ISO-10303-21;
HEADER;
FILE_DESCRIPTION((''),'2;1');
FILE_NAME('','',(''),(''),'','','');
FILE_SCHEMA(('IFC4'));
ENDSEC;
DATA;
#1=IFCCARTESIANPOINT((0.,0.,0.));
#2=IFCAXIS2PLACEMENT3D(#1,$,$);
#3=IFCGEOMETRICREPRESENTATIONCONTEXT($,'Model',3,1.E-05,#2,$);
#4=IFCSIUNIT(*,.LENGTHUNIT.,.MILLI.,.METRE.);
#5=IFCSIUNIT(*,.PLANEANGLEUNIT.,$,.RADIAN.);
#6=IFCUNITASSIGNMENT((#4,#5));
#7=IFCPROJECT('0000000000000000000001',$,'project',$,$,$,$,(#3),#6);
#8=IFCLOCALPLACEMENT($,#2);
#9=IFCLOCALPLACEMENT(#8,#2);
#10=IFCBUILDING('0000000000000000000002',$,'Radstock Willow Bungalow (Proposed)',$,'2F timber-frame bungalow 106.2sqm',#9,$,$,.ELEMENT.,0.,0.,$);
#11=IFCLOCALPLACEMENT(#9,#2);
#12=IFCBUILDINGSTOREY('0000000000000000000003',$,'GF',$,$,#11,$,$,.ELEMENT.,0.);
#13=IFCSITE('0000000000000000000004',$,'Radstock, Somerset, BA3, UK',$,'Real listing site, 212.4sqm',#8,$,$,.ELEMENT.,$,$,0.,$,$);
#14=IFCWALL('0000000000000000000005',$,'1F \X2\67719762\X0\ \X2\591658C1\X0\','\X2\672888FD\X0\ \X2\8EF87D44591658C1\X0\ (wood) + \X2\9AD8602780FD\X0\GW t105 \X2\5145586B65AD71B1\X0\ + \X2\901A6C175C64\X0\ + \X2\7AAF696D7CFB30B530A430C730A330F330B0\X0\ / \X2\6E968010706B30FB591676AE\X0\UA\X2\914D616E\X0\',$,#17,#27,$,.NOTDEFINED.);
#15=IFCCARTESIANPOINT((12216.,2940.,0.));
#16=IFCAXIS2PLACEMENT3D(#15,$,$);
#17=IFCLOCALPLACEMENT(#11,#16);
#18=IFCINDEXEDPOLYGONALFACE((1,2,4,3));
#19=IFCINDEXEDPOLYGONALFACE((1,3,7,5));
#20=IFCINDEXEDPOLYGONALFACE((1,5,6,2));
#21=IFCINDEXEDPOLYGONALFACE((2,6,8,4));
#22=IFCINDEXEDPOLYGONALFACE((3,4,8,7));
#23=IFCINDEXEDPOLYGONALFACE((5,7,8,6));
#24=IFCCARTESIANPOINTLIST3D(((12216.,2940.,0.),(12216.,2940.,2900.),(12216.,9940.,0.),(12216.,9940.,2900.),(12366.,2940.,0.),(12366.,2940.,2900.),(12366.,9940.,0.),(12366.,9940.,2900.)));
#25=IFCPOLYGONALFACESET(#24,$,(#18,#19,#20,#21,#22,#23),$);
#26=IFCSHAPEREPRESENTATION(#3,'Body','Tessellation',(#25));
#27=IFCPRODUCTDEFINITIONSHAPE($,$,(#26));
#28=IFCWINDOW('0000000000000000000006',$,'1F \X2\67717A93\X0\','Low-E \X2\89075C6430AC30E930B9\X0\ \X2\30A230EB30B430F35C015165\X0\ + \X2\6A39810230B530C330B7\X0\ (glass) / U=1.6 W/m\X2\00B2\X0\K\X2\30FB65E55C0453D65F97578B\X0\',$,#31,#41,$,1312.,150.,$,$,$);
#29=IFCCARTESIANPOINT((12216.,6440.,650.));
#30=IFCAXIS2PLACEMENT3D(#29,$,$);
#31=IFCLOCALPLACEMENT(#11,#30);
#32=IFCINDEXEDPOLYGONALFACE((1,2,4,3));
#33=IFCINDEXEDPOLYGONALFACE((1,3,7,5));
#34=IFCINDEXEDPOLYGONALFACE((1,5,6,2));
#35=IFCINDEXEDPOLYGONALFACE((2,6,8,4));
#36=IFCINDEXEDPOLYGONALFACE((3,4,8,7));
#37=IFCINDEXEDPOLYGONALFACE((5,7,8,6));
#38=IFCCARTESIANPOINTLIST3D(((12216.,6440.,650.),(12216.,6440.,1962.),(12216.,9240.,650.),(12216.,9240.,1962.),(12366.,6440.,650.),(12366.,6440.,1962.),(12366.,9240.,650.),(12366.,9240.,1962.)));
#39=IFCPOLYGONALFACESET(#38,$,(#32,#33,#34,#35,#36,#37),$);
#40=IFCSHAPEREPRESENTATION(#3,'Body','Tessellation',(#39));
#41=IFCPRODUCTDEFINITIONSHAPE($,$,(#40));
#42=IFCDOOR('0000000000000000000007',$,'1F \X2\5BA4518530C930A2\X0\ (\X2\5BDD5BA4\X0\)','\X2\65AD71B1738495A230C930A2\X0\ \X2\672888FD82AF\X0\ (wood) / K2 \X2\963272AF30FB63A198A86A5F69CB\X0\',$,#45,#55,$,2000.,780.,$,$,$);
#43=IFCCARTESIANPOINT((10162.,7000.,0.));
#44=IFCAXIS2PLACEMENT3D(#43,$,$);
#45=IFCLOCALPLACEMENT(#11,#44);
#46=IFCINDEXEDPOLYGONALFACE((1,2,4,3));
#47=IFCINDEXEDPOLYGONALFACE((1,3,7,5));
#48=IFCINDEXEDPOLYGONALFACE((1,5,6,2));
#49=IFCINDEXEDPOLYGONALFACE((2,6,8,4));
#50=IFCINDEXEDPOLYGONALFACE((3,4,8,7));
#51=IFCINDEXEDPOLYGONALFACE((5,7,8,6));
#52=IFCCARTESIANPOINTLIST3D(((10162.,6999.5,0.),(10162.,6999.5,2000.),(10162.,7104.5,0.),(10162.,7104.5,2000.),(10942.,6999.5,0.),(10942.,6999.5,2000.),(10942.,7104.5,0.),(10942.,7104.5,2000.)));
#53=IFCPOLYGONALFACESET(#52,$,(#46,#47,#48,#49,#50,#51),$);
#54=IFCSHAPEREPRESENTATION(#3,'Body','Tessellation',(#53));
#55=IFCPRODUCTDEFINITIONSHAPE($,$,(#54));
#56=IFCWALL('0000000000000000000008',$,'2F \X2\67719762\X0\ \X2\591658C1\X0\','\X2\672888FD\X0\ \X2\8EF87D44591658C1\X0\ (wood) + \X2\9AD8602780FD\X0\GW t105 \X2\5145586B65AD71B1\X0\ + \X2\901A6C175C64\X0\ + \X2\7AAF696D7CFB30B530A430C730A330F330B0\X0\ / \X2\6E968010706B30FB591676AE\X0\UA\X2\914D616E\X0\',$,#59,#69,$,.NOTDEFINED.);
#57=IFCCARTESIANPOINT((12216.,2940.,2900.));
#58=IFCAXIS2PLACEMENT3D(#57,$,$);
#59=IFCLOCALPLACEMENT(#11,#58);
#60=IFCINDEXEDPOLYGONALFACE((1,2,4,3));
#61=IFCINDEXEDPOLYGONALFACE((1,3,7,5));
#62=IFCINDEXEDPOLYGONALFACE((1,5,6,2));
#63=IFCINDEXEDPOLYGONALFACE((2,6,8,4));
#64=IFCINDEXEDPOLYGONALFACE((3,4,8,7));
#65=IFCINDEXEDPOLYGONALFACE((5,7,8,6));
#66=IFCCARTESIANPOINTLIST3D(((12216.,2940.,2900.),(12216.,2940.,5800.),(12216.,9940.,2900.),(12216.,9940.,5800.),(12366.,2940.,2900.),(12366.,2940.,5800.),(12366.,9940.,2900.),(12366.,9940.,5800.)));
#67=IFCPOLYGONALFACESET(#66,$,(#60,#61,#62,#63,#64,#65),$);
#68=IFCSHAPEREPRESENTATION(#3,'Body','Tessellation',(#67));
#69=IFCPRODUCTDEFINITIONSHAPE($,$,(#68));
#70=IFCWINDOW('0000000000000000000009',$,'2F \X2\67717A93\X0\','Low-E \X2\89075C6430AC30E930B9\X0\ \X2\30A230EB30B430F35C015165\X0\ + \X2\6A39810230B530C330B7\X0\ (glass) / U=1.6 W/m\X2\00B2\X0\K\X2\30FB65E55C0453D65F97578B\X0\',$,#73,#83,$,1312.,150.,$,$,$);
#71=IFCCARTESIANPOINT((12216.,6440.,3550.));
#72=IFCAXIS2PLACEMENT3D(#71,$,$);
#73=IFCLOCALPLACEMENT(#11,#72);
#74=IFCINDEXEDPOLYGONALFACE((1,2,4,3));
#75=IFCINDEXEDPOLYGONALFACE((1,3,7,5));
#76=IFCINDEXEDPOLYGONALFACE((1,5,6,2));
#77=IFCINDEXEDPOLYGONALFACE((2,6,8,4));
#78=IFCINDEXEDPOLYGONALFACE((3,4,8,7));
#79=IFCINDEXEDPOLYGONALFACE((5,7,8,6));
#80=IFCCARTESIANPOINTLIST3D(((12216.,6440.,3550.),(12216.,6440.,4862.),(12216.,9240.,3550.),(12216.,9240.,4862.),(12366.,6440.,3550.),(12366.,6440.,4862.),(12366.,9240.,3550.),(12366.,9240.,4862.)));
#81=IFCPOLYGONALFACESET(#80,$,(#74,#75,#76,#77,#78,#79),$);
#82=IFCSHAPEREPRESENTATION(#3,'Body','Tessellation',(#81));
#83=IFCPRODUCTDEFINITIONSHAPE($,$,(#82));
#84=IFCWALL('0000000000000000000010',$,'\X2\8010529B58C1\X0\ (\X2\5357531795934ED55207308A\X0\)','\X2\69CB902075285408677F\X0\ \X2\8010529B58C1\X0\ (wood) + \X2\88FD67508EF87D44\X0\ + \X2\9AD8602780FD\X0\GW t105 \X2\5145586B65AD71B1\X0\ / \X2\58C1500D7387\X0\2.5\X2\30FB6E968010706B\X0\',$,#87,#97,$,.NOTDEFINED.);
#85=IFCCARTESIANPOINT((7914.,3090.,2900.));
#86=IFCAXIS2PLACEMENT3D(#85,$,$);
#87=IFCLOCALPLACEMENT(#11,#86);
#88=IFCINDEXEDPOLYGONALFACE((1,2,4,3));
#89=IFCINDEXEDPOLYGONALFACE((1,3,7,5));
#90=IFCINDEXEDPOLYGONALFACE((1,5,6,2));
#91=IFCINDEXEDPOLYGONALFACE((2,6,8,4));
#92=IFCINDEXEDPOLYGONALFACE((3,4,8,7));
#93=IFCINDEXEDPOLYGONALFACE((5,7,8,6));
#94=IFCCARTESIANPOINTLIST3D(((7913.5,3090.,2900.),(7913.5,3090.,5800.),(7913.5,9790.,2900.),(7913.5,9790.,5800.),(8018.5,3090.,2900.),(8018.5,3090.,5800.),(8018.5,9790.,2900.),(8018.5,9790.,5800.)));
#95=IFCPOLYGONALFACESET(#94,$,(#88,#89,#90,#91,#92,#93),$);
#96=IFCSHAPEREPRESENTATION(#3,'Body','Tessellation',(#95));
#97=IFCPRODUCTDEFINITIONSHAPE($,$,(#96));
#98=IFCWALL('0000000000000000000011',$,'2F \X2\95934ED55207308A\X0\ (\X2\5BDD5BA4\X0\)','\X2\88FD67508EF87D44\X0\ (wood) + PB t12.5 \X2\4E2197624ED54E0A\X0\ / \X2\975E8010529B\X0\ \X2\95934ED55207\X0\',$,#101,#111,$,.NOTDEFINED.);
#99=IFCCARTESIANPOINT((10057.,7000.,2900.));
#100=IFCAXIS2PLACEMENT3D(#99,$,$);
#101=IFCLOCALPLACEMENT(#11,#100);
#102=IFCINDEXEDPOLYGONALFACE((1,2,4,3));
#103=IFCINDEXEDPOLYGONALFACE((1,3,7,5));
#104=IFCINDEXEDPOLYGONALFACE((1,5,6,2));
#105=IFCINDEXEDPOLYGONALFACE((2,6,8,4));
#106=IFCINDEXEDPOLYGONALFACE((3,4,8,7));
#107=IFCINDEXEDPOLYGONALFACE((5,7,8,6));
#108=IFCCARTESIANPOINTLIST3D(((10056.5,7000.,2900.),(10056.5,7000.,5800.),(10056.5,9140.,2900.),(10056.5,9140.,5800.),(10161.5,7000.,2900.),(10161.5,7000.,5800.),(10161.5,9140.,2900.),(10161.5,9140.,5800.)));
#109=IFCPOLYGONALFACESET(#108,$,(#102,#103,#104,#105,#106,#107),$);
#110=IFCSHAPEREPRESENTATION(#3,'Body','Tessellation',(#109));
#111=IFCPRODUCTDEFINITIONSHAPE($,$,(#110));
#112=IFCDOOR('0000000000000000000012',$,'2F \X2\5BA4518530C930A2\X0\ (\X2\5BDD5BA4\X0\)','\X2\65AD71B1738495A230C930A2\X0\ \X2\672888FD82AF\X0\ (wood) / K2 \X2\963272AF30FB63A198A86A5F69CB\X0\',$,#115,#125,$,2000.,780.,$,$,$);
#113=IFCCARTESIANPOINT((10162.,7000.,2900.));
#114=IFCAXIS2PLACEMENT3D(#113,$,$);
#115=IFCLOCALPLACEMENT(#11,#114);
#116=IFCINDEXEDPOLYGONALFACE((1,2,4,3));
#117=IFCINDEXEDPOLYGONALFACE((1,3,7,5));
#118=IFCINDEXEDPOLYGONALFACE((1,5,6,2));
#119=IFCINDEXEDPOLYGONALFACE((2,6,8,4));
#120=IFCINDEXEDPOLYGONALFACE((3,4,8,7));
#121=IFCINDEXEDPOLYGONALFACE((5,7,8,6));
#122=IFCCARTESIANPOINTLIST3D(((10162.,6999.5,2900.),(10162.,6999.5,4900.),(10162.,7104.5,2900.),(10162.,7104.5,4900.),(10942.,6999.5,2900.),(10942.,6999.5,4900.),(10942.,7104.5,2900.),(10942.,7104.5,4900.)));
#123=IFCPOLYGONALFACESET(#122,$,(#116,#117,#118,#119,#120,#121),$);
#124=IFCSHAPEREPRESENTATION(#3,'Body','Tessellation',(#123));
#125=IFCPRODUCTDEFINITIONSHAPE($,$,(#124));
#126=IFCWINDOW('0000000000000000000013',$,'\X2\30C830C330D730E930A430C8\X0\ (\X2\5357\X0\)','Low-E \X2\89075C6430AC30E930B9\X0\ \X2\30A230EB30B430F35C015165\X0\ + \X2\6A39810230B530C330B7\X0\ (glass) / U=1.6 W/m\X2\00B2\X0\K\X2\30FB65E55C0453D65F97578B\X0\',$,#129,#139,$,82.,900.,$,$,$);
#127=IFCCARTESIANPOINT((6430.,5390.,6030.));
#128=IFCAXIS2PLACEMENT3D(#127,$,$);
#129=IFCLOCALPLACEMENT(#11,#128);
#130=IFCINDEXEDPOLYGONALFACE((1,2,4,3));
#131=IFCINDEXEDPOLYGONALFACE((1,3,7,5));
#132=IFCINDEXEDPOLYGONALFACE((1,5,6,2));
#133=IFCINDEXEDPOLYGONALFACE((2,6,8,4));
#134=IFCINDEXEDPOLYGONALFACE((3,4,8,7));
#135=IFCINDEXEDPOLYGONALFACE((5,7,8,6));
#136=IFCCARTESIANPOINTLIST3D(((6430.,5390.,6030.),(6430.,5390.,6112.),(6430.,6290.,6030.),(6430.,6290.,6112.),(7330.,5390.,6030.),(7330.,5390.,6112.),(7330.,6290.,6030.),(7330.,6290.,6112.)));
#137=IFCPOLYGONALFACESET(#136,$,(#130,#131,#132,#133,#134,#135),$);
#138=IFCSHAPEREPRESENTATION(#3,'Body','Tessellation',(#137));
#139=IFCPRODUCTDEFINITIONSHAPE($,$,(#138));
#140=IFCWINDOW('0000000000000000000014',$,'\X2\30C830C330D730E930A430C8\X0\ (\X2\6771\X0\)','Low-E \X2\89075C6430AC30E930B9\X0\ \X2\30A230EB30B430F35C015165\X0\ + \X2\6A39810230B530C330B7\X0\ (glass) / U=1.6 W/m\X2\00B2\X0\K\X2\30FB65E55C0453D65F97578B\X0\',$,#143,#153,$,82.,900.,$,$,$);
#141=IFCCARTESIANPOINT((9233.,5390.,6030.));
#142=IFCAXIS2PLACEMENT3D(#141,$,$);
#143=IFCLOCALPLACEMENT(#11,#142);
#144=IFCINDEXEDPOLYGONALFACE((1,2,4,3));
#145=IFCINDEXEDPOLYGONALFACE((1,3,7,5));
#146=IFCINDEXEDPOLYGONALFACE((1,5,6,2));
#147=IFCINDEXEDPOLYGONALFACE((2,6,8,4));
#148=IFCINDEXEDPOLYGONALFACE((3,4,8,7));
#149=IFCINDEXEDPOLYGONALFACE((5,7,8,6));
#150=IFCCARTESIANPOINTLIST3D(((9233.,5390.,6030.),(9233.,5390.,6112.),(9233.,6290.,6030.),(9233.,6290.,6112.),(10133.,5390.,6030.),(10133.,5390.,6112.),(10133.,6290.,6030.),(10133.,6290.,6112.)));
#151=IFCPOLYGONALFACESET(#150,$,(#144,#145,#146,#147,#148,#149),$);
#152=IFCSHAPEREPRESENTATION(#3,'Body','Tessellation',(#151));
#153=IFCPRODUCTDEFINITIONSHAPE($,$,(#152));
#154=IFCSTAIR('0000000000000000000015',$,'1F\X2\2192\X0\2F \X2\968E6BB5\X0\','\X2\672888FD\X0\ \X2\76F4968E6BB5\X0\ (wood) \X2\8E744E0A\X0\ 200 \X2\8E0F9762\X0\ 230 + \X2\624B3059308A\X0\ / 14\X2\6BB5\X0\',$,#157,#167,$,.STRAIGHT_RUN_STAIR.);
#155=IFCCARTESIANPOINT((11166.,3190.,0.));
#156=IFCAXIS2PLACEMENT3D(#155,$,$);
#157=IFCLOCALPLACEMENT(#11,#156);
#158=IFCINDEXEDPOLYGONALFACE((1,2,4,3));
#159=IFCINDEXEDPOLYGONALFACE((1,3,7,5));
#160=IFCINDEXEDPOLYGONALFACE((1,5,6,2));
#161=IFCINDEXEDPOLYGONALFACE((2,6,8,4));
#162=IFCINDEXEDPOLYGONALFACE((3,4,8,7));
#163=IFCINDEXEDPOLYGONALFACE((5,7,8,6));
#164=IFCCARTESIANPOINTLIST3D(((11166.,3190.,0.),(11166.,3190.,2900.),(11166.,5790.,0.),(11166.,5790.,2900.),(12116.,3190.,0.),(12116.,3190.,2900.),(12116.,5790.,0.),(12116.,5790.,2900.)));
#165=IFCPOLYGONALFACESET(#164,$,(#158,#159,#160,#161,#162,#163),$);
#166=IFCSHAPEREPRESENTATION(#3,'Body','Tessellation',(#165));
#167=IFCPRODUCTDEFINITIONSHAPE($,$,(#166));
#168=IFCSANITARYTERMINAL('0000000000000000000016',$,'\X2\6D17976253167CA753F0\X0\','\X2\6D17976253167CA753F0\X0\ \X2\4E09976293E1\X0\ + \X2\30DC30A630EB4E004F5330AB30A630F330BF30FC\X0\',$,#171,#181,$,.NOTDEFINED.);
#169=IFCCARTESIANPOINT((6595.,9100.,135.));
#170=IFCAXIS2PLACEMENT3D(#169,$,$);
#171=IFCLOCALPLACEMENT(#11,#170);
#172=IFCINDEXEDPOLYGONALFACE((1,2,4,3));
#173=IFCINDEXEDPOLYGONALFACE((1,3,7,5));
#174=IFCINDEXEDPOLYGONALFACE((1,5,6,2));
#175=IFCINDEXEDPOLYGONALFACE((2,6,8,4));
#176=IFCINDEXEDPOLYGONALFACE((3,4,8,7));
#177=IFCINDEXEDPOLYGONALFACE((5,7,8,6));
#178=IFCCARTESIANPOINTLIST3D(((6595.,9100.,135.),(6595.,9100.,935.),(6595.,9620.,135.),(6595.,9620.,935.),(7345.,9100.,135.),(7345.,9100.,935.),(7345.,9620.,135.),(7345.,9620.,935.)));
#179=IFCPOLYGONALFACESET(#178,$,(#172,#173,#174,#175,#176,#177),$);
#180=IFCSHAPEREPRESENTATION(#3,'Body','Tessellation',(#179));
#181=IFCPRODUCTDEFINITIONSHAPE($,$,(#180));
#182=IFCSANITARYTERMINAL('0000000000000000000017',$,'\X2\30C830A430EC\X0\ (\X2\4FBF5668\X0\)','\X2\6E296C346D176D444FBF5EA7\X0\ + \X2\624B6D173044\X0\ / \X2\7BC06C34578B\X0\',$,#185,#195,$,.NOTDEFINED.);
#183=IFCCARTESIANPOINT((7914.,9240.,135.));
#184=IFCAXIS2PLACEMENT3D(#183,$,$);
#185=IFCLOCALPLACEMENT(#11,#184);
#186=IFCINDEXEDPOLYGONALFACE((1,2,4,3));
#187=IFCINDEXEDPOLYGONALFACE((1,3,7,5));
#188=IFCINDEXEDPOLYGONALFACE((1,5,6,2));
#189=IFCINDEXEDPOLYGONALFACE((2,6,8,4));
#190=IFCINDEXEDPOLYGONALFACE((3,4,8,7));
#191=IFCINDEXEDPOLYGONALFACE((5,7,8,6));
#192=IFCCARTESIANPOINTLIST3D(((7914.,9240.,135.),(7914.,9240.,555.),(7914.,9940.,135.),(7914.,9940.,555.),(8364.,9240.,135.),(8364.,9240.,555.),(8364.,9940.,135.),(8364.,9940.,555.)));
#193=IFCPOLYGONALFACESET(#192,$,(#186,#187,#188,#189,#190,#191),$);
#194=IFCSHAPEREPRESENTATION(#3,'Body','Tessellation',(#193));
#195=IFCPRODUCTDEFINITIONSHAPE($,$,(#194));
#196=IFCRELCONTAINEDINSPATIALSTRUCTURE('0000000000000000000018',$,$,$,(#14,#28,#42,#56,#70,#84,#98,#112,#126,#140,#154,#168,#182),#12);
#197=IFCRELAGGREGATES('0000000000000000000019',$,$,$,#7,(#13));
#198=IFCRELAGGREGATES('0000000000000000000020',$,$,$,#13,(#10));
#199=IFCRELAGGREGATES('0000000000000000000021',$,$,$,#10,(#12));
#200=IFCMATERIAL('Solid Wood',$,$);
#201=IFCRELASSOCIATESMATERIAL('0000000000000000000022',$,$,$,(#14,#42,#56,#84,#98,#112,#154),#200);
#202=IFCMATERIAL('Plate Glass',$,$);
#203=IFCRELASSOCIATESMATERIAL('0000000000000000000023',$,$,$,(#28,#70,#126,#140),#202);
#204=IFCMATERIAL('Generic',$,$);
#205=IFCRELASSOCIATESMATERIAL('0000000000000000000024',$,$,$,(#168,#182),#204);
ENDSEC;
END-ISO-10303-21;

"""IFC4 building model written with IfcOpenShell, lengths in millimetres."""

from ifc_helpers import new_model, si_unit, frame, frame_2d, origin, place, context, project, spatial, rectangle, extrude, material, element, fill, save


model = new_model("IFC4")

# Units and contexts
model_context = context("Model", 3, precision=1e-05, world=origin())
ifc_project = project(units=[si_unit("LENGTHUNIT", "METRE", prefix="MILLI"), si_unit("PLANEANGLEUNIT", "RADIAN")], contexts=[model_context])

# Site, building, storey
site_placement = place(None, origin())
site = spatial("IfcSite", under=ifc_project, at=site_placement, Name="Radstock, Somerset, BA3, UK", ObjectType="Real listing site, 212.4sqm", CompositionType="ELEMENT", RefElevation=0.0)
building_placement = place(site_placement, origin())
building = spatial("IfcBuilding", under=site, at=building_placement, Name="Radstock Willow Bungalow (Proposed)", ObjectType="2F timber-frame bungalow 106.2sqm", CompositionType="ELEMENT", ElevationOfRefHeight=0.0, ElevationOfTerrain=0.0)
storey_placement = place(building_placement, origin())
storey = spatial("IfcBuildingStorey", under=building, at=storey_placement, Name="GF", CompositionType="ELEMENT", Elevation=0.0)

# Wall, opening, window
ifc_material_1 = material(Name="Solid Wood")
wall_1_placement = place(storey_placement, frame((12216.0, 2940.0, 0.0)))
wall_1 = element("IfcWall", 1, at=wall_1_placement, inside=storey, material=ifc_material_1, Name="1F 東面 外壁", Description="木製 軸組外壁 (wood) + 高性能GW t105 充填断熱 + 通気層 + 窯業系サイディング / 準耐火・外皮UA配慮", PredefinedType="NOTDEFINED", context=model_context, shape_type="SweptSolid", body=[
    extrude(rectangle(XDim=150.0, YDim=7000.0, at=frame_2d((75.0, 3500.0))), frame((12216.0, 2940.0, 0.0)), (0.0, 0.0, 1.0), 2900.0),
])
opening_1_placement = place(storey_placement, frame((12216.0, 6440.0, 650.0)))
opening_1 = element("IfcOpeningElement", 2, at=opening_1_placement, cuts=wall_1, PredefinedType="NOTDEFINED", context=model_context, shape_type="SweptSolid", body=[
    extrude(rectangle(XDim=150.0, YDim=2800.0, at=frame_2d((75.0, 1400.0))), frame((12216.0, 6440.0, 650.0)), (0.0, 0.0, 1.0), 1312.0),
])
ifc_material_2 = material(Name="Plate Glass")
window_1_placement = place(storey_placement, frame((12216.0, 6440.0, 650.0)))
window_1 = element("IfcWindow", 3, at=window_1_placement, inside=storey, material=ifc_material_2, Name="1F 東窓", Description="Low-E 複層ガラス アルゴン封入 + 樹脂サッシ (glass) / U=1.6 W/m²K・日射取得型", OverallHeight=1312.0, OverallWidth=150.0, context=model_context, shape_type="SweptSolid", body=[
    extrude(rectangle(XDim=150.0, YDim=2800.0, at=frame_2d((75.0, 1400.0))), frame((12216.0, 6440.0, 650.0)), (0.0, 0.0, 1.0), 1312.0),
])
fill(opening_1, window_1)

# Door
door_1_placement = place(storey_placement, frame((10162.0, 7000.0, 0.0)))
element("IfcDoor", 4, at=door_1_placement, inside=storey, material=ifc_material_1, Name="1F 室内ドア (寝室)", Description="断熱玄関ドア 木製芯 (wood) / K2 防犯・採風機構", OverallHeight=2000.0, OverallWidth=780.0, context=model_context, shape_type="SweptSolid", body=[
    extrude(rectangle(XDim=780.0, YDim=105.0, at=frame_2d((390.0, 52.0))), frame((10162.0, 7000.0, 0.0)), (0.0, 0.0, 1.0), 2000.0),
])

# Wall, opening, window
wall_2_placement = place(storey_placement, frame((12216.0, 2940.0, 2900.0)))
wall_2 = element("IfcWall", 5, at=wall_2_placement, inside=storey, material=ifc_material_1, Name="2F 東面 外壁", Description="木製 軸組外壁 (wood) + 高性能GW t105 充填断熱 + 通気層 + 窯業系サイディング / 準耐火・外皮UA配慮", PredefinedType="NOTDEFINED", context=model_context, shape_type="SweptSolid", body=[
    extrude(rectangle(XDim=150.0, YDim=7000.0, at=frame_2d((75.0, 3500.0))), frame((12216.0, 2940.0, 2900.0)), (0.0, 0.0, 1.0), 2900.0),
])
opening_2_placement = place(storey_placement, frame((12216.0, 6440.0, 3550.0)))
opening_2 = element("IfcOpeningElement", 6, at=opening_2_placement, cuts=wall_2, PredefinedType="NOTDEFINED", context=model_context, shape_type="SweptSolid", body=[
    extrude(rectangle(XDim=150.0, YDim=2800.0, at=frame_2d((75.0, 1400.0))), frame((12216.0, 6440.0, 3550.0)), (0.0, 0.0, 1.0), 1312.0),
])
window_2_placement = place(storey_placement, frame((12216.0, 6440.0, 3550.0)))
window_2 = element("IfcWindow", 7, at=window_2_placement, inside=storey, material=ifc_material_2, Name="2F 東窓", Description="Low-E 複層ガラス アルゴン封入 + 樹脂サッシ (glass) / U=1.6 W/m²K・日射取得型", OverallHeight=1312.0, OverallWidth=150.0, context=model_context, shape_type="SweptSolid", body=[
    extrude(rectangle(XDim=150.0, YDim=2800.0, at=frame_2d((75.0, 1400.0))), frame((12216.0, 6440.0, 3550.0)), (0.0, 0.0, 1.0), 1312.0),
])
fill(opening_2, window_2)

# Walls
wall_3_placement = place(storey_placement, frame((7914.0, 3090.0, 2900.0)))
element("IfcWall", 8, at=wall_3_placement, inside=storey, material=ifc_material_1, Name="耐力壁 (南北間仕切り)", Description="構造用合板 耐力壁 (wood) + 製材軸組 + 高性能GW t105 充填断熱 / 壁倍率2.5・準耐火", PredefinedType="NOTDEFINED", context=model_context, shape_type="SweptSolid", body=[
    extrude(rectangle(XDim=105.0, YDim=6700.0, at=frame_2d((52.0, 3350.0))), frame((7914.0, 3090.0, 2900.0)), (0.0, 0.0, 1.0), 2900.0),
])
wall_4_placement = place(storey_placement, frame((10057.0, 7000.0, 2900.0)))
element("IfcWall", 9, at=wall_4_placement, inside=storey, material=ifc_material_1, Name="2F 間仕切り (寝室)", Description="製材軸組 (wood) + PB t12.5 両面仕上 / 非耐力 間仕切", PredefinedType="NOTDEFINED", context=model_context, shape_type="SweptSolid", body=[
    extrude(rectangle(XDim=105.0, YDim=2140.0, at=frame_2d((52.0, 1070.0))), frame((10057.0, 7000.0, 2900.0)), (0.0, 0.0, 1.0), 2900.0),
])

# Door
door_2_placement = place(storey_placement, frame((10162.0, 7000.0, 2900.0)))
element("IfcDoor", 10, at=door_2_placement, inside=storey, material=ifc_material_1, Name="2F 室内ドア (寝室)", Description="断熱玄関ドア 木製芯 (wood) / K2 防犯・採風機構", OverallHeight=2000.0, OverallWidth=780.0, context=model_context, shape_type="SweptSolid", body=[
    extrude(rectangle(XDim=780.0, YDim=105.0, at=frame_2d((390.0, 52.0))), frame((10162.0, 7000.0, 2900.0)), (0.0, 0.0, 1.0), 2000.0),
])

# Windows
window_3_placement = place(storey_placement, frame((6430.0, 5390.0, 6030.0)))
element("IfcWindow", 11, at=window_3_placement, inside=storey, material=ifc_material_2, Name="トップライト (南)", Description="Low-E 複層ガラス アルゴン封入 + 樹脂サッシ (glass) / U=1.6 W/m²K・日射取得型", OverallHeight=82.0, OverallWidth=900.0, context=model_context, shape_type="SweptSolid", body=[
    extrude(rectangle(XDim=900.0, YDim=900.0, at=frame_2d((450.0, 450.0))), frame((6430.0, 5390.0, 6030.0)), (0.0, 0.0, 1.0), 82.0),
])
window_4_placement = place(storey_placement, frame((9233.0, 5390.0, 6030.0)))
element("IfcWindow", 12, at=window_4_placement, inside=storey, material=ifc_material_2, Name="トップライト (東)", Description="Low-E 複層ガラス アルゴン封入 + 樹脂サッシ (glass) / U=1.6 W/m²K・日射取得型", OverallHeight=82.0, OverallWidth=900.0, context=model_context, shape_type="SweptSolid", body=[
    extrude(rectangle(XDim=900.0, YDim=900.0, at=frame_2d((450.0, 450.0))), frame((9233.0, 5390.0, 6030.0)), (0.0, 0.0, 1.0), 82.0),
])

# Stair
stair_placement = place(storey_placement, frame((11166.0, 3190.0, 0.0)))
element("IfcStair", 13, at=stair_placement, inside=storey, material=ifc_material_1, Name="1F→2F 階段", Description="木製 直階段 (wood) 蹴上 200 踏面 230 + 手すり / 14段", PredefinedType="STRAIGHT_RUN_STAIR", context=model_context, shape_type="SweptSolid", body=[
    extrude(rectangle(XDim=950.0, YDim=2600.0, at=frame_2d((475.0, 1300.0))), frame((11166.0, 3190.0, 0.0)), (0.0, 0.0, 1.0), 2900.0),
])

# Sanitary terminals
ifc_material_3 = material(Name="Generic")
sanitary_terminal_1_placement = place(storey_placement, frame((6595.0, 9100.0, 135.0)))
element("IfcSanitaryTerminal", 14, at=sanitary_terminal_1_placement, inside=storey, material=ifc_material_3, Name="洗面化粧台", Description="洗面化粧台 三面鏡 + ボウル一体カウンター", PredefinedType="NOTDEFINED", context=model_context, shape_type="SweptSolid", body=[
    extrude(rectangle(XDim=750.0, YDim=520.0, at=frame_2d((375.0, 260.0))), frame((6595.0, 9100.0, 135.0)), (0.0, 0.0, 1.0), 800.0),
])
sanitary_terminal_2_placement = place(storey_placement, frame((7914.0, 9240.0, 135.0)))
element("IfcSanitaryTerminal", 15, at=sanitary_terminal_2_placement, inside=storey, material=ifc_material_3, Name="トイレ (便器)", Description="温水洗浄便座 + 手洗い / 節水型", PredefinedType="NOTDEFINED", context=model_context, shape_type="SweptSolid", body=[
    extrude(rectangle(XDim=450.0, YDim=700.0, at=frame_2d((225.0, 350.0))), frame((7914.0, 9240.0, 135.0)), (0.0, 0.0, 1.0), 420.0),
])

save(model, "model.ifc")
